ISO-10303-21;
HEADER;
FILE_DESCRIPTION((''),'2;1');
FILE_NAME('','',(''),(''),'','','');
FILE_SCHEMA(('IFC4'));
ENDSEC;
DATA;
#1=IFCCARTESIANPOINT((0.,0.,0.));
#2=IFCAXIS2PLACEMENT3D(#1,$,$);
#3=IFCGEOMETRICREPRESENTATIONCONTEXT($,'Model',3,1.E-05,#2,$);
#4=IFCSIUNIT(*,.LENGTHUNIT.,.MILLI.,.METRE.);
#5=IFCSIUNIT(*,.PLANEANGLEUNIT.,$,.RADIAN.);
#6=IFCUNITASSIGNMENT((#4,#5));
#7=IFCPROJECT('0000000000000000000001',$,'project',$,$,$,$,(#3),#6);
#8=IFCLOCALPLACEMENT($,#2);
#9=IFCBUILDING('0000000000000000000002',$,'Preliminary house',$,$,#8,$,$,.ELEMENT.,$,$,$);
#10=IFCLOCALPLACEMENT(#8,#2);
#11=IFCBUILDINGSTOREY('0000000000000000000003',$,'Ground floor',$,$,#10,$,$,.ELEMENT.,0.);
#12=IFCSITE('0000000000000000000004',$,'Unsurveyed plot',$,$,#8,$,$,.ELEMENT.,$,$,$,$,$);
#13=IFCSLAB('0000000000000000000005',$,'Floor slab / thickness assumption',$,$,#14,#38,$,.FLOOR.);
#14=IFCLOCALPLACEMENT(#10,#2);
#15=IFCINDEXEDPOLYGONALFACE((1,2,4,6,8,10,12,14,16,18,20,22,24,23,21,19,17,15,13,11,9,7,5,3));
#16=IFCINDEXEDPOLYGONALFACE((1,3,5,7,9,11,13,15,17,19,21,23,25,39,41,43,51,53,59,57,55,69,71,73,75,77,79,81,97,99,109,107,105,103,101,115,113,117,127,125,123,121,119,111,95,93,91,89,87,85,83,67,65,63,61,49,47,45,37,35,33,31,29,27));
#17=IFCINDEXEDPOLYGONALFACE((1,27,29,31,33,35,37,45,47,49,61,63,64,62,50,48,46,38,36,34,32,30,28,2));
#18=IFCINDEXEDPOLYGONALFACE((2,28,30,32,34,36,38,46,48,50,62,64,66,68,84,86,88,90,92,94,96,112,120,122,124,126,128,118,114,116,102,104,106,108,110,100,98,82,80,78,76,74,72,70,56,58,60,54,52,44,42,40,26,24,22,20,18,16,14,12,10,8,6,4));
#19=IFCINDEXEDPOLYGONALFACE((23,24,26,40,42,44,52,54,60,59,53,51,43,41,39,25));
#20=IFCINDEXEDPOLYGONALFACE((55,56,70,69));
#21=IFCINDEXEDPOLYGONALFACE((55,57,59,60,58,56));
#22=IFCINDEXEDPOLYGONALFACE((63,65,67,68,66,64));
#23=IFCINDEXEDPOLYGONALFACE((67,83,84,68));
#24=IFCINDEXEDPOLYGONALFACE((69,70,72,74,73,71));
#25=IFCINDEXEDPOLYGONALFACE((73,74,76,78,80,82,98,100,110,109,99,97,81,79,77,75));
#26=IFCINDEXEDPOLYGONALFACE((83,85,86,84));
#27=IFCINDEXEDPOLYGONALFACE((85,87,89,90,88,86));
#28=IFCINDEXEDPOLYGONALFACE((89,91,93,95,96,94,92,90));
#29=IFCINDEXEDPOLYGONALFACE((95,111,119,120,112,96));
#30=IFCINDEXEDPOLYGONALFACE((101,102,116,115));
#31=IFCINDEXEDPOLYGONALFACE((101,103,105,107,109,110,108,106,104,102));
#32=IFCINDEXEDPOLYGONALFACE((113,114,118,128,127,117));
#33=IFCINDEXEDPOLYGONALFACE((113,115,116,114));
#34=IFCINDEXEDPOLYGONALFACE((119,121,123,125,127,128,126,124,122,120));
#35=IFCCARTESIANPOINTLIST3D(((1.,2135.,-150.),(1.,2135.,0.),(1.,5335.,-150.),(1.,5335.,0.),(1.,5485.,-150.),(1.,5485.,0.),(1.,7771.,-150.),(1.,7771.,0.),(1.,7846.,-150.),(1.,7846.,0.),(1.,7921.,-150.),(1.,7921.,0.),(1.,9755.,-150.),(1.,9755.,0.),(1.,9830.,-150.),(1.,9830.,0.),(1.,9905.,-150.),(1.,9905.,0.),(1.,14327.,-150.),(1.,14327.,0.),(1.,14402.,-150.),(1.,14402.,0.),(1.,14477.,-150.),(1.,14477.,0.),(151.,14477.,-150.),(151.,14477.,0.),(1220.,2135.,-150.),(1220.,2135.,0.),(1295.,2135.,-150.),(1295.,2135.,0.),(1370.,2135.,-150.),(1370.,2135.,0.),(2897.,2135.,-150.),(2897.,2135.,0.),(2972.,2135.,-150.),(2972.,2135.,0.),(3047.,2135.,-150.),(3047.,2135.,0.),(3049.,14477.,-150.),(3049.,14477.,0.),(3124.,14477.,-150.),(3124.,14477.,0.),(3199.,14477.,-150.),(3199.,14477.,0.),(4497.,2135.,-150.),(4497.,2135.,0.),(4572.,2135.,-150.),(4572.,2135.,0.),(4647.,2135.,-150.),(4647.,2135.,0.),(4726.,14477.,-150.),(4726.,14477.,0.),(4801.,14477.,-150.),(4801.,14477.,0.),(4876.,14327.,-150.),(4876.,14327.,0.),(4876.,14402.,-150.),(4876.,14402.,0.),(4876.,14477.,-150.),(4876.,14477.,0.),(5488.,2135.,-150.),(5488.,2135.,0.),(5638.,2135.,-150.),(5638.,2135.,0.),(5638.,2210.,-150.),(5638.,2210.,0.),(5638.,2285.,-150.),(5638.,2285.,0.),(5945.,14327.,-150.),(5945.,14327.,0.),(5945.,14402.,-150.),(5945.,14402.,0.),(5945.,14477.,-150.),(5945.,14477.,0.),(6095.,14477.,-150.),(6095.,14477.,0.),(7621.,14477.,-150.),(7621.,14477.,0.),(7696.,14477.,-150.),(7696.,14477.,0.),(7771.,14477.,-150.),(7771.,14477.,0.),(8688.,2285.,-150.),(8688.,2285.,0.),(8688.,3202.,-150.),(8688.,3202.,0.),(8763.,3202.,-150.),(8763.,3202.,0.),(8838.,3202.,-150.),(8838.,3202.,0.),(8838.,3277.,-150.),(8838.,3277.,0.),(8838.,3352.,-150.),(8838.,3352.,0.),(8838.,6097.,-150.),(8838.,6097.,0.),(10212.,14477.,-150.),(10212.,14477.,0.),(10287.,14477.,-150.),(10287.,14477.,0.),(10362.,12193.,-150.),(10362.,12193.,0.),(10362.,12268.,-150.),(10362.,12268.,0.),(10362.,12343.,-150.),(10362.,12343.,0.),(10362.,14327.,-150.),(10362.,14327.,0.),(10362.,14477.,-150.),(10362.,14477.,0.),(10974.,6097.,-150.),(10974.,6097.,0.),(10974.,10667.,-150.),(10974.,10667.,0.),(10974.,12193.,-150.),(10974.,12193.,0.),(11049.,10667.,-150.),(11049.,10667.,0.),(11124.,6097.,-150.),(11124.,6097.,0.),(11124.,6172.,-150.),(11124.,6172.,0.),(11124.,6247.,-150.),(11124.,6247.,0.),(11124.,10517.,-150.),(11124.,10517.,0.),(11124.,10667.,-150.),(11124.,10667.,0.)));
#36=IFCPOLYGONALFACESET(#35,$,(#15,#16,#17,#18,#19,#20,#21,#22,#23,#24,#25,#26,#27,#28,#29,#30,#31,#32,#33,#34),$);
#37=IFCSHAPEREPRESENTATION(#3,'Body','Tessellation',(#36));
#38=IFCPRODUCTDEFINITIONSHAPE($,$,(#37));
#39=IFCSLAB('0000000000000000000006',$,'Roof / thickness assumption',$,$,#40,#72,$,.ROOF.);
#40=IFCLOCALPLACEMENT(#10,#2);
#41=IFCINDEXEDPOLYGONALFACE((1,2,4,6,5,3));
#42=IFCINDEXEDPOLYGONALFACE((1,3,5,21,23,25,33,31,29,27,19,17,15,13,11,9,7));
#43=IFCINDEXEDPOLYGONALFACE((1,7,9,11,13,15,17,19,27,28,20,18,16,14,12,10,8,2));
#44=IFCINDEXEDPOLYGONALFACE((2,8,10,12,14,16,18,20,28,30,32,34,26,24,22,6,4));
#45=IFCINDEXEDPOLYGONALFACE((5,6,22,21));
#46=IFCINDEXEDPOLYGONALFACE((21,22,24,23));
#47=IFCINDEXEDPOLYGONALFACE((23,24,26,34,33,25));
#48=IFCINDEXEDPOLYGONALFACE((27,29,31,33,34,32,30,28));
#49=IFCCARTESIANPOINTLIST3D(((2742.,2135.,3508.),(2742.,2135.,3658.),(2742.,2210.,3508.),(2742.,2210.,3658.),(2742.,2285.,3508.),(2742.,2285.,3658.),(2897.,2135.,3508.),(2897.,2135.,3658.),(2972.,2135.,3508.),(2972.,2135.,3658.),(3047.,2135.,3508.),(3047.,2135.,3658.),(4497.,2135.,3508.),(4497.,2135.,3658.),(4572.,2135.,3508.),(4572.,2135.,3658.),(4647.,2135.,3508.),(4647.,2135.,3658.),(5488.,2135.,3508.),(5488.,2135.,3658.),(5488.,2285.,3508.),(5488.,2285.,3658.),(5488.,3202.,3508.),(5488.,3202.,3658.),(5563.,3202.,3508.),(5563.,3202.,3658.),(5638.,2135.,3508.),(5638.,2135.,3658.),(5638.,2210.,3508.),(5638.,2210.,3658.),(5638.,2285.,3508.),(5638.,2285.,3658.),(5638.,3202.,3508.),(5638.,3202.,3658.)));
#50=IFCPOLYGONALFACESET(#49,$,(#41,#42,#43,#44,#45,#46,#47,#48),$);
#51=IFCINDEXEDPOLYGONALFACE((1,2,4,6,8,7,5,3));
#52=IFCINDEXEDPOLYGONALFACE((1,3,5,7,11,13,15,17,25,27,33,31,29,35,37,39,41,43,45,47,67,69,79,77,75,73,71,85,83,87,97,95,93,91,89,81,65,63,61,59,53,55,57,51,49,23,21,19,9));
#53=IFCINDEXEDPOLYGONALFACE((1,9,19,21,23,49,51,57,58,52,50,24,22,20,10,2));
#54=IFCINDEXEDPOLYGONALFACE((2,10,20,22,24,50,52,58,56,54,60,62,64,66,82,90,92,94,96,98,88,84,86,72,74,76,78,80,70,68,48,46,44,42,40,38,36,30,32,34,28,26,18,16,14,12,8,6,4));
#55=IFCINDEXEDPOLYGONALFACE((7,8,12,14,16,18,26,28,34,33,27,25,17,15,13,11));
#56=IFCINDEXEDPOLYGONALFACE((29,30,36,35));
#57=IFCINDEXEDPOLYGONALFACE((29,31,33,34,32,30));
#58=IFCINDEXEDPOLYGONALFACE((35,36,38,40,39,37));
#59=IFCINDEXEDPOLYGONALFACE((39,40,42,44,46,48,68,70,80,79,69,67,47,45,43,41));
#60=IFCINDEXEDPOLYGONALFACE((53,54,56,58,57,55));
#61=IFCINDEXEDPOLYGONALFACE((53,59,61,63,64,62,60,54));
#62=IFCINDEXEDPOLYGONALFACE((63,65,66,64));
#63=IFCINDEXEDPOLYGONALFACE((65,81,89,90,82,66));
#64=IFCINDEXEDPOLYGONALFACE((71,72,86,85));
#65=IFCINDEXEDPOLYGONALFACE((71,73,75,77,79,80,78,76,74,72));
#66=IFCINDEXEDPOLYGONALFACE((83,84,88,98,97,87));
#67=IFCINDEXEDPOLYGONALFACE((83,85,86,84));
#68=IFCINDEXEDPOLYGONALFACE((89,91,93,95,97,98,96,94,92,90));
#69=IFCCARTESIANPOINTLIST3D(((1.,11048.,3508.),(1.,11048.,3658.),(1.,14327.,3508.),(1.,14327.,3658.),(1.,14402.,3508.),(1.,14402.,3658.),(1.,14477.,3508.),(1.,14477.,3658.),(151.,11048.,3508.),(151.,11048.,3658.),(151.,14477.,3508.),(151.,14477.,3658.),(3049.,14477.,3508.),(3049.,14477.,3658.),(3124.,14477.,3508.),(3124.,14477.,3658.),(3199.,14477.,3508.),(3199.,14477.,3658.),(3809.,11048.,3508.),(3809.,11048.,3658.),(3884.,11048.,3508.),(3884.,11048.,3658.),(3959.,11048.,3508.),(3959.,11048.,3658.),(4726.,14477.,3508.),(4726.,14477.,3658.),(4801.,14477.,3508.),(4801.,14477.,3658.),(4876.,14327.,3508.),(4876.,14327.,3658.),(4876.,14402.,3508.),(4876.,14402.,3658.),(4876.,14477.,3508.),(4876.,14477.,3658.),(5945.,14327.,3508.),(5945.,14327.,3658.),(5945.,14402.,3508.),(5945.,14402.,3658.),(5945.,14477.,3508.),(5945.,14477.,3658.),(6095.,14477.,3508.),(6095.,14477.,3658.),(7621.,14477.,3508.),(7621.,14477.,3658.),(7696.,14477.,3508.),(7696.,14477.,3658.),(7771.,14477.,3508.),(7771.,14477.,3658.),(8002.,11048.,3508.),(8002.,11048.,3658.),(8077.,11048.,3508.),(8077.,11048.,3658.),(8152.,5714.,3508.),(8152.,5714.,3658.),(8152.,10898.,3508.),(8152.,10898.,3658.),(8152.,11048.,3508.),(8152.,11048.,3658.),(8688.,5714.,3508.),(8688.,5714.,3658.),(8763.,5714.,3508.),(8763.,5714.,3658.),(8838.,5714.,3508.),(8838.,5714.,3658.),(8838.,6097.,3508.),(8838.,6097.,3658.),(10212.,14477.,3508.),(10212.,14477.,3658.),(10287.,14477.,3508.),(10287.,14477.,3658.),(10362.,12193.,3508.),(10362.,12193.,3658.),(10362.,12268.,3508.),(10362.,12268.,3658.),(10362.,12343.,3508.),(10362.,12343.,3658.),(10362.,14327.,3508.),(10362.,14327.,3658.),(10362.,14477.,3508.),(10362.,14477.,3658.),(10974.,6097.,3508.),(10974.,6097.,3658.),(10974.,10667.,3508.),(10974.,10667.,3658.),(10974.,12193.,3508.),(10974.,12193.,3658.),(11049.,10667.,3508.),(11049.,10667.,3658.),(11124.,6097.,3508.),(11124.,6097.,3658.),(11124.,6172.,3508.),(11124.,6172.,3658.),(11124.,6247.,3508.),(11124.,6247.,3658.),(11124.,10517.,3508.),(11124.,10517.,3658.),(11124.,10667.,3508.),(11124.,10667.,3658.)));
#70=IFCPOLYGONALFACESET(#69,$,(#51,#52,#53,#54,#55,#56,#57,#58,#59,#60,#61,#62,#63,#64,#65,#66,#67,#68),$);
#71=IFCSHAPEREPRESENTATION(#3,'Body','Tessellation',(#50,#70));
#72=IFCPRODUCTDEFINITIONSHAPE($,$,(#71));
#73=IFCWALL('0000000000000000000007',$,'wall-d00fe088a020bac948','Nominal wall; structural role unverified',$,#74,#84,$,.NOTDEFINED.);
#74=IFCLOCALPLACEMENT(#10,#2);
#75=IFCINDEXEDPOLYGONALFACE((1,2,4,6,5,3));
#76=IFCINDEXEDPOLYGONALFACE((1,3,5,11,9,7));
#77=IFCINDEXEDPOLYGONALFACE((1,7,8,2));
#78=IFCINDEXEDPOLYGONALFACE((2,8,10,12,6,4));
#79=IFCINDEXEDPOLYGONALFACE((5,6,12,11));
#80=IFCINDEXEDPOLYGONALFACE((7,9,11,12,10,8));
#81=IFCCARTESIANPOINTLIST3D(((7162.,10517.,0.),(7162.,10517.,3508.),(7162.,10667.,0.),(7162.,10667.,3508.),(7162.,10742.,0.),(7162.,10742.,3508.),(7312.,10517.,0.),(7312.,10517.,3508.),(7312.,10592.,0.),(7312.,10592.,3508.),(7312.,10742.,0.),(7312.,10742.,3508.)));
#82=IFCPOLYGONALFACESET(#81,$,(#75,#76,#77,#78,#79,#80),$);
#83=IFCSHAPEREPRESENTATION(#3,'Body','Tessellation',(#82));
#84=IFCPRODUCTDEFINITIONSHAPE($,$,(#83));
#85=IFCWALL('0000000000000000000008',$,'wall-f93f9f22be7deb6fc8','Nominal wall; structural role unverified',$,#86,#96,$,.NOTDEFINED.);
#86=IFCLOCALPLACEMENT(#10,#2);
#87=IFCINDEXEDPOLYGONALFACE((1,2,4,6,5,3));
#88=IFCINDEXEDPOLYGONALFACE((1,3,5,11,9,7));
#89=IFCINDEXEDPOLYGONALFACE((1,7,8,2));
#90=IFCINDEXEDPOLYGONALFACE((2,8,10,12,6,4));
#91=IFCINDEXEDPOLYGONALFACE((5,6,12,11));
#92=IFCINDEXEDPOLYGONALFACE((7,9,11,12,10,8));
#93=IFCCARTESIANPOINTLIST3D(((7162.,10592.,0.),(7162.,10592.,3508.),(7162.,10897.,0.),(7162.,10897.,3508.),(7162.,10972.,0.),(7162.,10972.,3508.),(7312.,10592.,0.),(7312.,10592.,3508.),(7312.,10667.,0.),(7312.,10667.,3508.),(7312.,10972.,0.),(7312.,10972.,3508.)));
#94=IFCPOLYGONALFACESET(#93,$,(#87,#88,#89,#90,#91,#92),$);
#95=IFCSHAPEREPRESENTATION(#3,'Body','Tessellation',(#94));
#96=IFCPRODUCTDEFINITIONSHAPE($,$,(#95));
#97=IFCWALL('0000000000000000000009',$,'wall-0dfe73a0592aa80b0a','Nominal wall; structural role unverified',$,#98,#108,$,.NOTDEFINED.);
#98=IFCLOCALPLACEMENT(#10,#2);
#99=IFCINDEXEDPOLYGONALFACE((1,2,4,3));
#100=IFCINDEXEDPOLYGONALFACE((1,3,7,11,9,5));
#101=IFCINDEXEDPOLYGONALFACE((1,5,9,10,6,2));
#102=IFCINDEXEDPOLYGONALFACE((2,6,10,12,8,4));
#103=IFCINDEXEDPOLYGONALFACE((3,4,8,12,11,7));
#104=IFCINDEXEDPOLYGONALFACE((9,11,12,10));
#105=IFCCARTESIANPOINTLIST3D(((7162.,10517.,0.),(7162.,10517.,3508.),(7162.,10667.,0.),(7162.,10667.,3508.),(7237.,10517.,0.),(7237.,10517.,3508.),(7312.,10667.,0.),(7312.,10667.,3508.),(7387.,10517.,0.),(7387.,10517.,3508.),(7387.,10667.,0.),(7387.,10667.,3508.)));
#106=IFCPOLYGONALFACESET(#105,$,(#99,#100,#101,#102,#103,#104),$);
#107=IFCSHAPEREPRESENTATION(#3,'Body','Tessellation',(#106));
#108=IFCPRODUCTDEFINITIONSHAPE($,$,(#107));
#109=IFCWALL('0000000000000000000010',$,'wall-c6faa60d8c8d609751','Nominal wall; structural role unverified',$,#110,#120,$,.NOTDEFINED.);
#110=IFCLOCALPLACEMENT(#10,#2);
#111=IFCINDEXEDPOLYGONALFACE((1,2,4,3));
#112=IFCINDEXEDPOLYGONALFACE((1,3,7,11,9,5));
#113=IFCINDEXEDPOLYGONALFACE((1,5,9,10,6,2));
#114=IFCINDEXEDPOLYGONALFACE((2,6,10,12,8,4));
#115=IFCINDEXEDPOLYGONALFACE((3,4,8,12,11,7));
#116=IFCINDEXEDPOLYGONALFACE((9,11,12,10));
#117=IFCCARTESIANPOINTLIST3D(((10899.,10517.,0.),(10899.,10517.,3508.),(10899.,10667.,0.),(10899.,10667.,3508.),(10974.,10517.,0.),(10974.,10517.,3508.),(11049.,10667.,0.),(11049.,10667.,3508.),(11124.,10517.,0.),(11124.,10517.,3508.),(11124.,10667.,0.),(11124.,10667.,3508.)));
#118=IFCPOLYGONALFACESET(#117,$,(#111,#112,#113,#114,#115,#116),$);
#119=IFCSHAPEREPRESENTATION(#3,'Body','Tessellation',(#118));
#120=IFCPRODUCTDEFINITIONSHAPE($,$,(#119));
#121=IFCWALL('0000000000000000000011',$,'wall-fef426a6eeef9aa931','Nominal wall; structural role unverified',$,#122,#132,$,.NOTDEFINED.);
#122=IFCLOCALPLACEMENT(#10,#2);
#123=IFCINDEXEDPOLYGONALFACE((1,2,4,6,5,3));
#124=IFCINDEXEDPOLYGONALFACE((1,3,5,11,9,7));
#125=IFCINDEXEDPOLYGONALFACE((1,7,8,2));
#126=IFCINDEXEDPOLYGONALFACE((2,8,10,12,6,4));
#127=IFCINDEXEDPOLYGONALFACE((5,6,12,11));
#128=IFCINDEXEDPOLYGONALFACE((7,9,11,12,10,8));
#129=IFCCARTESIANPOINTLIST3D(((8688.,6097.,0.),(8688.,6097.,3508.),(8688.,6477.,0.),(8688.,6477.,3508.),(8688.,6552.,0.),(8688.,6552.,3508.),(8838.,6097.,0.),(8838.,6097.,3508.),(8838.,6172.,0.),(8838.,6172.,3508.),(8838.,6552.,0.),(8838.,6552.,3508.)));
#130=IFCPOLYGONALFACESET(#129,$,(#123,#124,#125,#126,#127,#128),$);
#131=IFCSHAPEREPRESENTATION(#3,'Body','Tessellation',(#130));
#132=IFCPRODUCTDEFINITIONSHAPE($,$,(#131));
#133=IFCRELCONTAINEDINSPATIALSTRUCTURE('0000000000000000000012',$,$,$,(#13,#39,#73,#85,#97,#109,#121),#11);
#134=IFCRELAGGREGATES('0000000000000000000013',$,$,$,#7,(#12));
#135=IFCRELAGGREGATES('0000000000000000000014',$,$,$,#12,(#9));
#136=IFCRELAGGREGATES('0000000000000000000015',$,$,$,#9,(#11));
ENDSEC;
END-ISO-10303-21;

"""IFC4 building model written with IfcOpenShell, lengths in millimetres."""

from ifc_helpers import new_model, si_unit, frame, origin, place, context, project, spatial, polyline, outline, extrude, element, save


model = new_model("IFC4")

# Units and contexts
model_context = context("Model", 3, precision=1e-05, world=origin())
ifc_project = project(units=[si_unit("LENGTHUNIT", "METRE", prefix="MILLI"), si_unit("PLANEANGLEUNIT", "RADIAN")], contexts=[model_context])

# Site, building, storey
placement_1 = place(None, origin())
site = spatial("IfcSite", under=ifc_project, at=placement_1, Name="Unsurveyed plot", CompositionType="ELEMENT")
building = spatial("IfcBuilding", under=site, at=placement_1, Name="Preliminary house", CompositionType="ELEMENT")
placement_2 = place(placement_1, origin())
storey = spatial("IfcBuildingStorey", under=building, at=placement_2, Name="Ground floor", CompositionType="ELEMENT", Elevation=0.0)

# Slabs
element("IfcSlab", 1, at=placement_2, inside=storey, Name="Floor slab / thickness assumption", PredefinedType="FLOOR", context=model_context, shape_type="SweptSolid", body=[
    extrude(outline(polyline([(1370.0, 2135.0), (1295.0, 2135.0), (1220.0, 2135.0), (1.0, 2135.0), (1.0, 5335.0), (1.0, 5485.0), (1.0, 7771.0), (1.0, 7846.0), (1.0, 7921.0), (1.0, 9755.0), (1.0, 9830.0), (1.0, 9905.0), (1.0, 14327.0), (1.0, 14402.0), (1.0, 14477.0), (151.0, 14477.0), (3049.0, 14477.0), (3124.0, 14477.0), (3199.0, 14477.0), (4726.0, 14477.0), (4801.0, 14477.0), (4876.0, 14477.0), (4876.0, 14402.0), (4876.0, 14327.0), (5945.0, 14327.0), (5945.0, 14402.0), (5945.0, 14477.0), (6095.0, 14477.0), (7621.0, 14477.0), (7696.0, 14477.0), (7771.0, 14477.0), (10212.0, 14477.0), (10287.0, 14477.0), (10362.0, 14477.0), (10362.0, 14327.0), (10362.0, 12343.0), (10362.0, 12268.0), (10362.0, 12193.0), (10974.0, 12193.0), (10974.0, 10667.0), (11049.0, 10667.0), (11124.0, 10667.0), (11124.0, 10517.0), (11124.0, 6247.0), (11124.0, 6172.0), (11124.0, 6097.0), (10974.0, 6097.0), (8838.0, 6097.0), (8838.0, 3352.0), (8838.0, 3277.0), (8838.0, 3202.0), (8763.0, 3202.0), (8688.0, 3202.0), (8688.0, 2285.0), (5638.0, 2285.0), (5638.0, 2210.0), (5638.0, 2135.0), (5488.0, 2135.0), (4647.0, 2135.0), (4572.0, 2135.0), (4497.0, 2135.0), (3047.0, 2135.0), (2972.0, 2135.0), (2897.0, 2135.0), (1370.0, 2135.0)])), frame((0.0, 0.0, -150.0)), (0.0, 0.0, 1.0), 150.0),
])
element("IfcSlab", 2, at=placement_2, inside=storey, Name="Roof / thickness assumption", PredefinedType="ROOF", context=model_context, shape_type="SweptSolid", body=[
    extrude(outline(polyline([(5638.0, 2210.0), (5638.0, 2135.0), (5488.0, 2135.0), (4647.0, 2135.0), (4572.0, 2135.0), (4497.0, 2135.0), (3047.0, 2135.0), (2972.0, 2135.0), (2897.0, 2135.0), (2742.0, 2135.0), (2742.0, 2210.0), (2742.0, 2285.0), (5488.0, 2285.0), (5488.0, 3202.0), (5563.0, 3202.0), (5638.0, 3202.0), (5638.0, 2285.0), (5638.0, 2210.0)])), frame((0.0, 0.0, 3508.0)), (0.0, 0.0, 1.0), 150.0),
    extrude(outline(polyline([(1.0, 14402.0), (1.0, 14477.0), (151.0, 14477.0), (3049.0, 14477.0), (3124.0, 14477.0), (3199.0, 14477.0), (4726.0, 14477.0), (4801.0, 14477.0), (4876.0, 14477.0), (4876.0, 14402.0), (4876.0, 14327.0), (5945.0, 14327.0), (5945.0, 14402.0), (5945.0, 14477.0), (6095.0, 14477.0), (7621.0, 14477.0), (7696.0, 14477.0), (7771.0, 14477.0), (10212.0, 14477.0), (10287.0, 14477.0), (10362.0, 14477.0), (10362.0, 14327.0), (10362.0, 12343.0), (10362.0, 12268.0), (10362.0, 12193.0), (10974.0, 12193.0), (10974.0, 10667.0), (11049.0, 10667.0), (11124.0, 10667.0), (11124.0, 10517.0), (11124.0, 6247.0), (11124.0, 6172.0), (11124.0, 6097.0), (10974.0, 6097.0), (8838.0, 6097.0), (8838.0, 5714.0), (8763.0, 5714.0), (8688.0, 5714.0), (8152.0, 5714.0), (8152.0, 10898.0), (8152.0, 11048.0), (8077.0, 11048.0), (8002.0, 11048.0), (3959.0, 11048.0), (3884.0, 11048.0), (3809.0, 11048.0), (151.0, 11048.0), (1.0, 11048.0), (1.0, 14327.0), (1.0, 14402.0)])), frame((0.0, 0.0, 3508.0)), (0.0, 0.0, 1.0), 150.0),
])

# Walls
element("IfcWall", 3, at=placement_2, inside=storey, Name="wall-d00fe088a020bac948", Description="Nominal wall; structural role unverified", PredefinedType="NOTDEFINED", context=model_context, shape_type="SweptSolid", body=[
    extrude(outline(polyline([(7162.0, 10667.0), (7162.0, 10742.0), (7312.0, 10742.0), (7312.0, 10592.0), (7312.0, 10517.0), (7162.0, 10517.0), (7162.0, 10667.0)])), origin(), (0.0, 0.0, 1.0), 3508.0),
])
element("IfcWall", 4, at=placement_2, inside=storey, Name="wall-f93f9f22be7deb6fc8", Description="Nominal wall; structural role unverified", PredefinedType="NOTDEFINED", context=model_context, shape_type="SweptSolid", body=[
    extrude(outline(polyline([(7162.0, 10897.0), (7162.0, 10972.0), (7312.0, 10972.0), (7312.0, 10667.0), (7312.0, 10592.0), (7162.0, 10592.0), (7162.0, 10897.0)])), origin(), (0.0, 0.0, 1.0), 3508.0),
])
element("IfcWall", 5, at=placement_2, inside=storey, Name="wall-0dfe73a0592aa80b0a", Description="Nominal wall; structural role unverified", PredefinedType="NOTDEFINED", context=model_context, shape_type="SweptSolid", body=[
    extrude(outline(polyline([(7312.0, 10667.0), (7387.0, 10667.0), (7387.0, 10517.0), (7237.0, 10517.0), (7162.0, 10517.0), (7162.0, 10667.0), (7312.0, 10667.0)])), origin(), (0.0, 0.0, 1.0), 3508.0),
])

# Wall
element("IfcWall", 6, at=placement_2, inside=storey, Name="wall-c6faa60d8c8d609751", Description="Nominal wall; structural role unverified", PredefinedType="NOTDEFINED", context=model_context, shape_type="SweptSolid", body=[
    extrude(outline(polyline([(11049.0, 10667.0), (11124.0, 10667.0), (11124.0, 10517.0), (10974.0, 10517.0), (10899.0, 10517.0), (10899.0, 10667.0), (11049.0, 10667.0)])), origin(), (0.0, 0.0, 1.0), 3508.0),
])

# Wall
element("IfcWall", 7, at=placement_2, inside=storey, Name="wall-fef426a6eeef9aa931", Description="Nominal wall; structural role unverified", PredefinedType="NOTDEFINED", context=model_context, shape_type="SweptSolid", body=[
    extrude(outline(polyline([(8688.0, 6477.0), (8688.0, 6552.0), (8838.0, 6552.0), (8838.0, 6172.0), (8838.0, 6097.0), (8688.0, 6097.0), (8688.0, 6477.0)])), origin(), (0.0, 0.0, 1.0), 3508.0),
])

save(model, "model.ifc")
